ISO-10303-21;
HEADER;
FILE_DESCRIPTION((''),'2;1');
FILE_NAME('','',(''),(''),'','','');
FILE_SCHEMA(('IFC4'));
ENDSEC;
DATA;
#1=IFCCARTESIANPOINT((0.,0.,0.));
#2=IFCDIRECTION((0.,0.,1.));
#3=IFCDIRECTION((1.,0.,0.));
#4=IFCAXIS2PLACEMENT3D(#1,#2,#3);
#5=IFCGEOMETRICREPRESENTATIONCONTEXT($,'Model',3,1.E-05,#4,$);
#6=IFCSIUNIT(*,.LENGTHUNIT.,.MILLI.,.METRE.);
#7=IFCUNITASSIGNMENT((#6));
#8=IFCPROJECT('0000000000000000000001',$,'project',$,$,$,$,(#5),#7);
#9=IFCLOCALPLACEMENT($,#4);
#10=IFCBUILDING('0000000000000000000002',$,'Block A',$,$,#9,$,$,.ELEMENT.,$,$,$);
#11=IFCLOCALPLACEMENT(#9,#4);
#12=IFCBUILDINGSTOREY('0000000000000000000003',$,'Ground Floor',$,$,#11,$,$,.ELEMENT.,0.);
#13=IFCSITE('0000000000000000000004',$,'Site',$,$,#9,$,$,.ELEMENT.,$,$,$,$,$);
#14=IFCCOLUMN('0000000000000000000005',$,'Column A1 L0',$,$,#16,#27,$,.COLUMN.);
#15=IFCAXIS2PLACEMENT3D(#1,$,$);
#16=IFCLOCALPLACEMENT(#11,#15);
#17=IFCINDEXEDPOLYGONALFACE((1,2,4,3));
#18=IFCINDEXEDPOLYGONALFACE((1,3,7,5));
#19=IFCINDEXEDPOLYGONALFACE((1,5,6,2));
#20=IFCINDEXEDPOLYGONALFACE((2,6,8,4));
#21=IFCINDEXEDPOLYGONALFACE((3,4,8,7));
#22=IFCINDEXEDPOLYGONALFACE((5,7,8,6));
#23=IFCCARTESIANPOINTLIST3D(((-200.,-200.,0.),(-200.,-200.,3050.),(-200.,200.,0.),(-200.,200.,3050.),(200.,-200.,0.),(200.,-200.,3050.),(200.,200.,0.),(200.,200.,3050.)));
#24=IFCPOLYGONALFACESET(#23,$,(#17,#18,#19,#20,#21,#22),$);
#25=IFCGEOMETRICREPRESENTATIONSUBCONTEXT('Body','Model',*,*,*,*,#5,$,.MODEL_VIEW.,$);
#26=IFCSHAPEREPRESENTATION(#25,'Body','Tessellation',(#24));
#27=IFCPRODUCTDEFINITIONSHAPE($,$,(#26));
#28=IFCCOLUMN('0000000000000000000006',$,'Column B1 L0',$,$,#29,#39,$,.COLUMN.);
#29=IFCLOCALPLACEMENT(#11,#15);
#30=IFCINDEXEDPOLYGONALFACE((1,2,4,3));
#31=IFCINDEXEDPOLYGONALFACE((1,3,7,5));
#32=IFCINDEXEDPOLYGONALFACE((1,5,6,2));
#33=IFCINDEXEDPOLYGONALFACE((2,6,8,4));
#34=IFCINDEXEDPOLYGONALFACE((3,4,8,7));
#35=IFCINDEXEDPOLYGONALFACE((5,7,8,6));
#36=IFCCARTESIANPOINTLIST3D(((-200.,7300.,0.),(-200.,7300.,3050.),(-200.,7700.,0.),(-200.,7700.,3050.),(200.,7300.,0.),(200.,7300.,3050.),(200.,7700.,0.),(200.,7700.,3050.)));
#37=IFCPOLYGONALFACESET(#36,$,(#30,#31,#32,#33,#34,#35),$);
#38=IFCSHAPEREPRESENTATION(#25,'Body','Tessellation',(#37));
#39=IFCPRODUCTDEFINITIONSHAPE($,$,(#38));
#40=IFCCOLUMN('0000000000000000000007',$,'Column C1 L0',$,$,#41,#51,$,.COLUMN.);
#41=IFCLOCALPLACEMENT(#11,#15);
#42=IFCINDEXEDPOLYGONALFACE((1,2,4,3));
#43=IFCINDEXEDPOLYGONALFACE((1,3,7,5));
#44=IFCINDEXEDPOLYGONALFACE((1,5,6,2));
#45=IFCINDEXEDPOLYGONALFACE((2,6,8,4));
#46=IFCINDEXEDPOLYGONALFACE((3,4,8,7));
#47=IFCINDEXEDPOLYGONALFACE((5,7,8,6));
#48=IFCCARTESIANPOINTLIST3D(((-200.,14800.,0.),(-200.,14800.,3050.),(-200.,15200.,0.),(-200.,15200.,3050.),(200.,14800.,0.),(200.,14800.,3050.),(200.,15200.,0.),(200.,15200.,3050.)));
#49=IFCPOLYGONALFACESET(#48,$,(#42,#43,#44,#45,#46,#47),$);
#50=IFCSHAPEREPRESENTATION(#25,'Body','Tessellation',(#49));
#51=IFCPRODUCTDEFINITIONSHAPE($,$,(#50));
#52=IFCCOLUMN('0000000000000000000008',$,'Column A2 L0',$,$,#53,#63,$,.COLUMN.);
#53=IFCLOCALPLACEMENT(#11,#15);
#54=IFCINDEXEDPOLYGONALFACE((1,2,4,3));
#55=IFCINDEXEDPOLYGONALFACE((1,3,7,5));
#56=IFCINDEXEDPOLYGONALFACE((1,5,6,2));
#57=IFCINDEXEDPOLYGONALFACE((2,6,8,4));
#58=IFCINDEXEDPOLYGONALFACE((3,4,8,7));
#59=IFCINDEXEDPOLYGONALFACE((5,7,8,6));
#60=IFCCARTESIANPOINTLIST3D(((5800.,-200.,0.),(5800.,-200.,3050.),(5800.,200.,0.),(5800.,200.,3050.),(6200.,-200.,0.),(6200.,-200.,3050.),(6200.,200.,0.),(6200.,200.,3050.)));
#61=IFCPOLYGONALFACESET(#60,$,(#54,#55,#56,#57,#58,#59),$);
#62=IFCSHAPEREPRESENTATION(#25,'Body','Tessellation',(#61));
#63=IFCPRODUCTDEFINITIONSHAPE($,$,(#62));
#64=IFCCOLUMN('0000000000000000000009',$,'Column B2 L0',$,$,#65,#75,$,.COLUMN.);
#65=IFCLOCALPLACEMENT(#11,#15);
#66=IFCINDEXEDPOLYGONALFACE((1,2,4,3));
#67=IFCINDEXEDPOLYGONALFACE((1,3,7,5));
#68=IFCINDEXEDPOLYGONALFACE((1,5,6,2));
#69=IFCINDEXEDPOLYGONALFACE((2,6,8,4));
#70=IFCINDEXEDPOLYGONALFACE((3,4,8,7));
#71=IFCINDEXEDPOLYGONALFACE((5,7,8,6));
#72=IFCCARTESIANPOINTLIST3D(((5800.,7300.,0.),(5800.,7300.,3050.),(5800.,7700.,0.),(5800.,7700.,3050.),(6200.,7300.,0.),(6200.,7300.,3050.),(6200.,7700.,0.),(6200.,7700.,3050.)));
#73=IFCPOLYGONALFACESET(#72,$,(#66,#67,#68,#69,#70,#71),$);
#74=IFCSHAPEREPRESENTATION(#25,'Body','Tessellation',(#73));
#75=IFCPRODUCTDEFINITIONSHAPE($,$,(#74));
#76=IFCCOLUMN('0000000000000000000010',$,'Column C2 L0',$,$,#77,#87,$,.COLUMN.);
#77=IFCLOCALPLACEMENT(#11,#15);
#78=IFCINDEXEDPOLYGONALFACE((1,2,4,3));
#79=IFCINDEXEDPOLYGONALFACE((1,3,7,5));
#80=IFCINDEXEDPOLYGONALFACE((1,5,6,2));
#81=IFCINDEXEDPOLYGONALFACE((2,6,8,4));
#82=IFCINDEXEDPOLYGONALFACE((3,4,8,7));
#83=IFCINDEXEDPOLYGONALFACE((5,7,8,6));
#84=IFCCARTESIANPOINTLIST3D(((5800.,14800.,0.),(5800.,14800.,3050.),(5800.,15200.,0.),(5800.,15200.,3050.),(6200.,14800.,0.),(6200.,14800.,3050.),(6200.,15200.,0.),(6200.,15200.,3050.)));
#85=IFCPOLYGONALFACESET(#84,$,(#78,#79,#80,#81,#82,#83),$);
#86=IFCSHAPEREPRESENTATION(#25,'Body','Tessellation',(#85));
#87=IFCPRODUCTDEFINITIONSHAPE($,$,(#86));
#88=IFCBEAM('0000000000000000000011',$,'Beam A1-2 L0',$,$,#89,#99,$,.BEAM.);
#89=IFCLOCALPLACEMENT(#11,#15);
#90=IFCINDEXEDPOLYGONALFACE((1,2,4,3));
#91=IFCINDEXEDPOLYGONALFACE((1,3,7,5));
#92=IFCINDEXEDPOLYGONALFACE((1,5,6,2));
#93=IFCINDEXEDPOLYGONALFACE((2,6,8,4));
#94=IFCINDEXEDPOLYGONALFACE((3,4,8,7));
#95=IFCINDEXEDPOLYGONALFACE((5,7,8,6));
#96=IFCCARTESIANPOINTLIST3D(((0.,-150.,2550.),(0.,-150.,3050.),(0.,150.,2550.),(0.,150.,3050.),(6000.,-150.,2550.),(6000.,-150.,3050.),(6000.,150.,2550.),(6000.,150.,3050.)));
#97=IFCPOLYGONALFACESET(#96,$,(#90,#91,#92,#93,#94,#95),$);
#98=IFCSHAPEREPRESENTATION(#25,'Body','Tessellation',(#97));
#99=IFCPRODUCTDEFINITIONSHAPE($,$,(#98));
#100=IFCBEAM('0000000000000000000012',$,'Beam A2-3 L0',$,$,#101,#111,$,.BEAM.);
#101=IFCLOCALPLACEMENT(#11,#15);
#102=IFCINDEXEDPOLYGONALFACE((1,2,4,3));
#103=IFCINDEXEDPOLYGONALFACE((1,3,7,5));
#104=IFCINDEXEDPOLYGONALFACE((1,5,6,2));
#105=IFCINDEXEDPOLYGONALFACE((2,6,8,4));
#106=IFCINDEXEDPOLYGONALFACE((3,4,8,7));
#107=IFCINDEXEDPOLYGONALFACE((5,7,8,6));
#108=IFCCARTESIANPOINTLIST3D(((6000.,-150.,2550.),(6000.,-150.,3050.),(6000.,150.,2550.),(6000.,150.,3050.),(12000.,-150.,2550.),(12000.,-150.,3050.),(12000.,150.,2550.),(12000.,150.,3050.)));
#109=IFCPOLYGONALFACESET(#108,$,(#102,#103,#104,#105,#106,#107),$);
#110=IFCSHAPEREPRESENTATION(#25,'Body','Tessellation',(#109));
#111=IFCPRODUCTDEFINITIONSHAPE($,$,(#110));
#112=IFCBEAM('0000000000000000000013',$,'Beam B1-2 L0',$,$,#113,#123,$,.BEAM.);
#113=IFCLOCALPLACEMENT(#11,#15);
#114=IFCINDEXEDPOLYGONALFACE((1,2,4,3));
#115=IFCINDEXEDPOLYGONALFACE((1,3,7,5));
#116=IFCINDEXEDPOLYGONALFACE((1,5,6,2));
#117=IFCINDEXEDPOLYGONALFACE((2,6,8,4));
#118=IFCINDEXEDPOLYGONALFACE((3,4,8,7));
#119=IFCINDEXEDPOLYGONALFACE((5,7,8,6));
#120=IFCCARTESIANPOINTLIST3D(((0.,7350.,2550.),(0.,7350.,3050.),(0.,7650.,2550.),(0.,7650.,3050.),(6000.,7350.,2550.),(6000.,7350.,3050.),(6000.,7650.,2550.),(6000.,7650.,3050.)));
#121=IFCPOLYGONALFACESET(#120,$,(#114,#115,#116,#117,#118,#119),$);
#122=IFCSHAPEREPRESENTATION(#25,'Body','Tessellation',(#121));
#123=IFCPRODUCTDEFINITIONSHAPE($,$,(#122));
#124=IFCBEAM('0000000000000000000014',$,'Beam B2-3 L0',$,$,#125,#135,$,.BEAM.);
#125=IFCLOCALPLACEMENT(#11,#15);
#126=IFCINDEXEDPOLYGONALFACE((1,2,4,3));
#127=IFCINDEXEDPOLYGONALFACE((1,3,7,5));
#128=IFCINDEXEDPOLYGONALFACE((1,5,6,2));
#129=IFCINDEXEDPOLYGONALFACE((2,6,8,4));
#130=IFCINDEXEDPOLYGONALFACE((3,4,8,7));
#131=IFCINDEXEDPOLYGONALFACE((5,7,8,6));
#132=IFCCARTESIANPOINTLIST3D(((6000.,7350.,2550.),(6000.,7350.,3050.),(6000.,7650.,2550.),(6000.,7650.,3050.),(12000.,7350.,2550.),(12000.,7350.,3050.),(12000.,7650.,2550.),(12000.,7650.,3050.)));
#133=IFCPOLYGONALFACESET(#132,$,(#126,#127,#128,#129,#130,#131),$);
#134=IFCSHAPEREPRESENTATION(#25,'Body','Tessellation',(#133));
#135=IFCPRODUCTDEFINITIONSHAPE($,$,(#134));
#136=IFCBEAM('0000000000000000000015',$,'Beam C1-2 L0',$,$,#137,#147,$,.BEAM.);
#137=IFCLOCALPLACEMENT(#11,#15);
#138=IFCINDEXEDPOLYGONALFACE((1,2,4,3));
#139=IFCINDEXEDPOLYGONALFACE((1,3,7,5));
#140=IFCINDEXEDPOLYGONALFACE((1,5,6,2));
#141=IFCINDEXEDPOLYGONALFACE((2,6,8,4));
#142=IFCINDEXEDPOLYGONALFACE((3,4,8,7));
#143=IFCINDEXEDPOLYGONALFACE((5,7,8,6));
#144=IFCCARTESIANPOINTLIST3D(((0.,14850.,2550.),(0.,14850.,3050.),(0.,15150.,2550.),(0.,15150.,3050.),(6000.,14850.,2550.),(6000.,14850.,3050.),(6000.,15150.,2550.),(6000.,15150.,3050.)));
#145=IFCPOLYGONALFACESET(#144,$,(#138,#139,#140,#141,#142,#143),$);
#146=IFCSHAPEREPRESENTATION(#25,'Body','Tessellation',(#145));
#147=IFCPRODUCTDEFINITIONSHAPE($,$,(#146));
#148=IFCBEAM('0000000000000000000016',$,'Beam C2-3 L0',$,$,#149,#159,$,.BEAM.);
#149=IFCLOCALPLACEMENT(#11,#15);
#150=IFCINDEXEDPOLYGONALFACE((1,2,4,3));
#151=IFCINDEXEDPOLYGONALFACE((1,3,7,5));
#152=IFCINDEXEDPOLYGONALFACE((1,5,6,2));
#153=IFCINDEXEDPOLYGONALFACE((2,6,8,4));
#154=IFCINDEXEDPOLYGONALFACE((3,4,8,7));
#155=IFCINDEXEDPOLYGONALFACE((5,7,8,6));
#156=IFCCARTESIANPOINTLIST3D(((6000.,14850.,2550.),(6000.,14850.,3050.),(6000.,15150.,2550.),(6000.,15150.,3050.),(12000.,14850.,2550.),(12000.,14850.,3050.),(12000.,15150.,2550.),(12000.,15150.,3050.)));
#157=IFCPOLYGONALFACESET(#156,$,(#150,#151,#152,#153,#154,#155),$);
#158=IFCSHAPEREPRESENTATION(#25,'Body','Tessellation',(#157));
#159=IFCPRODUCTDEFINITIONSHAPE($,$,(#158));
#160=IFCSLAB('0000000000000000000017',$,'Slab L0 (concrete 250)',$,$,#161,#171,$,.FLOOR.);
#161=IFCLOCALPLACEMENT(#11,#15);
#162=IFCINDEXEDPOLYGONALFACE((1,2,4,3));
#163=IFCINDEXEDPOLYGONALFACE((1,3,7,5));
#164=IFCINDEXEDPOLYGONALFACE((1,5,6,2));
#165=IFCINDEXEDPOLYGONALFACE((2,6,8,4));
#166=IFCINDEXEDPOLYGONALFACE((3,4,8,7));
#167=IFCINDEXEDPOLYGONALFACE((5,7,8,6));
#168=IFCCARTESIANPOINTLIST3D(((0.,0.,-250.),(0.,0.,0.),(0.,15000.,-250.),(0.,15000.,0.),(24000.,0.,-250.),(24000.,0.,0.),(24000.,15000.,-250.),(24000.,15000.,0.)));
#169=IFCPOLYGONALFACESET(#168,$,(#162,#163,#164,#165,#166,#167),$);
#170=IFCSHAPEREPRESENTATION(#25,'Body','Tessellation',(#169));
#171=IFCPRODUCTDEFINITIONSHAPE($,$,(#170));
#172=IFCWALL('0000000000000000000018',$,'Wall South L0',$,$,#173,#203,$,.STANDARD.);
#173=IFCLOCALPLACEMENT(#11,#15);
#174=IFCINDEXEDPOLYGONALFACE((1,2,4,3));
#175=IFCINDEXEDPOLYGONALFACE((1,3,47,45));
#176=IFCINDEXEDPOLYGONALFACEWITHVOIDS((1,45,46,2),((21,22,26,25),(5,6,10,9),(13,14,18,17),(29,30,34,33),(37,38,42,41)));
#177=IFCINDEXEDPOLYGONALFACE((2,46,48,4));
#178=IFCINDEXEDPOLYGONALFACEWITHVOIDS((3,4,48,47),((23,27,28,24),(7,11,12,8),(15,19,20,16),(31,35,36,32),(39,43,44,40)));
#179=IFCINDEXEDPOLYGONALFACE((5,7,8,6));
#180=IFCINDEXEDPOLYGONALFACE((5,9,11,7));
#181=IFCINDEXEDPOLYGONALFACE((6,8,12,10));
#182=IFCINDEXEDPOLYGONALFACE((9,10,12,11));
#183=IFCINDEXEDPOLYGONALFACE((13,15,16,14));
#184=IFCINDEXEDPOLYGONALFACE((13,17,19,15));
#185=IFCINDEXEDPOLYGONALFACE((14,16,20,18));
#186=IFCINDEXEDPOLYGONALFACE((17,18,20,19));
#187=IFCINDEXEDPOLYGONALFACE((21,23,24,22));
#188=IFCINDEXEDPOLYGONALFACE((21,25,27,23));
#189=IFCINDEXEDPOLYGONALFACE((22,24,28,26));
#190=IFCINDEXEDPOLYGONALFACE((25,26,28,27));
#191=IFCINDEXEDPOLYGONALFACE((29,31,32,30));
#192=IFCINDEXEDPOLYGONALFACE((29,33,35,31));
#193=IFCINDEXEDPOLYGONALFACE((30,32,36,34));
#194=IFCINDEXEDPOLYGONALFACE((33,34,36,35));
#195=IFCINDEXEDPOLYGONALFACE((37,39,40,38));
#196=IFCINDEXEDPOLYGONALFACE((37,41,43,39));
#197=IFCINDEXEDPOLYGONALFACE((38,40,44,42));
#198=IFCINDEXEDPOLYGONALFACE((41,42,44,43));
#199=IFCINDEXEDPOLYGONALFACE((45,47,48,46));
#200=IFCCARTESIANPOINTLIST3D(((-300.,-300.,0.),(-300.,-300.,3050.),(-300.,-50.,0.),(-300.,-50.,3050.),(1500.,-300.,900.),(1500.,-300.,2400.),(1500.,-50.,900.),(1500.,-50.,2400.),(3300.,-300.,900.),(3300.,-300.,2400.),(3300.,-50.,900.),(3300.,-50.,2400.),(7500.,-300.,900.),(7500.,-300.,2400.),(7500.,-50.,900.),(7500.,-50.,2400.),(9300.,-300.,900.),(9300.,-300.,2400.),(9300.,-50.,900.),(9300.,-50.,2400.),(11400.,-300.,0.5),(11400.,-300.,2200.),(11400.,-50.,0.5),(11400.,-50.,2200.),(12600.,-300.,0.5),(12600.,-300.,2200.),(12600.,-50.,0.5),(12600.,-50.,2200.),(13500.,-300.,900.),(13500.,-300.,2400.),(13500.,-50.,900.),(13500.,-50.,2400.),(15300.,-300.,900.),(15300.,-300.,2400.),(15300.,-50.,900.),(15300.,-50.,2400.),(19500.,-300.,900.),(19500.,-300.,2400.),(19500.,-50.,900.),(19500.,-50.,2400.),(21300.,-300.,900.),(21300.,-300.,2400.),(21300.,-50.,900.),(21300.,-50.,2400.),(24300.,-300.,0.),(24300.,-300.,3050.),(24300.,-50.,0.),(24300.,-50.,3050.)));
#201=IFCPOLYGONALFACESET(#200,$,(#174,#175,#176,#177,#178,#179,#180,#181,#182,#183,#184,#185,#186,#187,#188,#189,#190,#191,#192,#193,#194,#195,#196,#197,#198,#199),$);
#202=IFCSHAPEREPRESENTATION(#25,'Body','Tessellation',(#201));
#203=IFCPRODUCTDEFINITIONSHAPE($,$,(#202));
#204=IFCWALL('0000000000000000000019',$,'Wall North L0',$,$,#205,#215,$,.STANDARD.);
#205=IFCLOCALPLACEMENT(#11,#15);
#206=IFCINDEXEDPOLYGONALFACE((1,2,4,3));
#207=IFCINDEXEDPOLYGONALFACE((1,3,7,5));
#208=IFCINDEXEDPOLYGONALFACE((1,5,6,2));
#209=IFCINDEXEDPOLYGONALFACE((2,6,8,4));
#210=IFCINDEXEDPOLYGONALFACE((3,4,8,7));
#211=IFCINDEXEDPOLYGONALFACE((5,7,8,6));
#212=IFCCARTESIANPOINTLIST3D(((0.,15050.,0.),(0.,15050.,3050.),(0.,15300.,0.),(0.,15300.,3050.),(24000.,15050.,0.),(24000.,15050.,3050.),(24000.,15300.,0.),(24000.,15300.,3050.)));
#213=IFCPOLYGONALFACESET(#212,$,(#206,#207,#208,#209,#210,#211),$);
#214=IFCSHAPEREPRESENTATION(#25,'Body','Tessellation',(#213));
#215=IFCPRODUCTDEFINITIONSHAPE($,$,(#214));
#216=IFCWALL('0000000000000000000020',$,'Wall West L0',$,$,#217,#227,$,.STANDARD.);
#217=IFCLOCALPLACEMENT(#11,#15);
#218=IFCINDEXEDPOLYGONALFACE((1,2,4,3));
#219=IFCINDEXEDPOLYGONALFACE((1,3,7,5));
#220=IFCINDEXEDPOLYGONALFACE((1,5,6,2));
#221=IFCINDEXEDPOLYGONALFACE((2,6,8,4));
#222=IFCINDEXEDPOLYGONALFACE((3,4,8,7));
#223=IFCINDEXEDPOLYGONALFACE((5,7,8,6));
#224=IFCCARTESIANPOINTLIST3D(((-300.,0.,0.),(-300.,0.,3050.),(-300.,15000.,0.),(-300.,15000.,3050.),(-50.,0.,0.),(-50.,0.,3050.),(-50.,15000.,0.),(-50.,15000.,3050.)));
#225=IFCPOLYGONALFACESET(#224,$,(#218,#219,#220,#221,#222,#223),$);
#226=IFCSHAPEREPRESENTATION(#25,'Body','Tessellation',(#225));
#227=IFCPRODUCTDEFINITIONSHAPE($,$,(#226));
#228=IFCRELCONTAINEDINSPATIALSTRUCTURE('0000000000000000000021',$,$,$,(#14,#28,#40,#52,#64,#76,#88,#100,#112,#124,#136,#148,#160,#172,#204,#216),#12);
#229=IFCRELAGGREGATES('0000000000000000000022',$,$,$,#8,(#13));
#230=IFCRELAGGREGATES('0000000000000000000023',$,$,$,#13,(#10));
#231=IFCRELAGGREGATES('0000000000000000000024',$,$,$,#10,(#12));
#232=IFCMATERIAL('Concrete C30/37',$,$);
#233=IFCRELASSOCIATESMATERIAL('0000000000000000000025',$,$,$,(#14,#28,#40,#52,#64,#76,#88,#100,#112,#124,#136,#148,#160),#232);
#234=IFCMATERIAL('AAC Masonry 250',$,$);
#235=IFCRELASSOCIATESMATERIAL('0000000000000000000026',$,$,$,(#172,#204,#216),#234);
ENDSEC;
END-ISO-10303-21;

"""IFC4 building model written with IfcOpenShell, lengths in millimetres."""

from ifc_helpers import new_model, si_unit, frame, frame_2d, origin_with_axes, origin_2d, place, context, subcontext, project, spatial, polyline, rectangle, outline, extrude, material, element, save


model = new_model("IFC4")

# Units and contexts
model_context = context("Model", 3, precision=1e-05, world=origin_with_axes())
body_context = subcontext(model_context, "Body", "Model", "MODEL_VIEW")
ifc_project = project(units=[si_unit("LENGTHUNIT", "METRE", prefix="MILLI")], contexts=[model_context])

# Site, building, storey
placement = place(None, origin_with_axes())
site = spatial("IfcSite", under=ifc_project, at=placement, Name="Site", CompositionType="ELEMENT")
building = spatial("IfcBuilding", under=site, at=placement, Name="Block A", CompositionType="ELEMENT")
storey_placement = place(placement, origin_with_axes())
storey = spatial("IfcBuildingStorey", under=building, at=storey_placement, Name="Ground Floor", CompositionType="ELEMENT", Elevation=0.0)

# Columns
ifc_material_1 = material(Name="Concrete C30/37")
for number, where, z_axis, x_axis, name in (
    (1, (0.0, 0.0, 0.0), (0.0, 0.0, 1.0), (1.0, 0.0, 0.0), "Column A1 L0"),
    (2, (0.0, 7500.0, 0.0), (0.0, 0.0, 1.0), (1.0, 0.0, 0.0), "Column B1 L0"),
    (3, (0.0, 15000.0, 0.0), (0.0, 0.0, 1.0), (1.0, 0.0, 0.0), "Column C1 L0"),
    (4, (6000.0, 0.0, 0.0), (0.0, 0.0, 1.0), (1.0, 0.0, 0.0), "Column A2 L0"),
    (5, (6000.0, 7500.0, 0.0), (0.0, 0.0, 1.0), (1.0, 0.0, 0.0), "Column B2 L0"),
    (6, (6000.0, 15000.0, 0.0), (0.0, 0.0, 1.0), (1.0, 0.0, 0.0), "Column C2 L0"),
):
    element("IfcColumn", number, at=place(placement, frame(where, z_axis=z_axis, x_axis=x_axis)), inside=storey, material=ifc_material_1, Name=name, PredefinedType="COLUMN", context=body_context, shape_type="SweptSolid", body=[
        extrude(rectangle(XDim=400.0, YDim=400.0, at=origin_2d()), origin_with_axes(), (0.0, 0.0, 1.0), 3050.0),
    ])

# Beams
for number, where, z_axis, x_axis, name in (
    (7, (0.0, 0.0, 2550.0), (0.0, 0.0, 1.0), (1.0, 0.0, 0.0), "Beam A1-2 L0"),
    (8, (6000.0, 0.0, 2550.0), (0.0, 0.0, 1.0), (1.0, 0.0, 0.0), "Beam A2-3 L0"),
    (9, (0.0, 7500.0, 2550.0), (0.0, 0.0, 1.0), (1.0, 0.0, 0.0), "Beam B1-2 L0"),
    (10, (6000.0, 7500.0, 2550.0), (0.0, 0.0, 1.0), (1.0, 0.0, 0.0), "Beam B2-3 L0"),
    (11, (0.0, 15000.0, 2550.0), (0.0, 0.0, 1.0), (1.0, 0.0, 0.0), "Beam C1-2 L0"),
    (12, (6000.0, 15000.0, 2550.0), (0.0, 0.0, 1.0), (1.0, 0.0, 0.0), "Beam C2-3 L0"),
):
    element("IfcBeam", number, at=place(placement, frame(where, z_axis=z_axis, x_axis=x_axis)), inside=storey, material=ifc_material_1, Name=name, PredefinedType="BEAM", context=body_context, shape_type="SweptSolid", body=[
        extrude(rectangle(XDim=6000.0, YDim=300.0, at=frame_2d((3000.0, 0.0))), origin_with_axes(), (0.0, 0.0, 1.0), 500.0),
    ])

# Slab
slab_placement = place(placement, frame((0.0, 0.0, -250.0), z_axis=(0.0, 0.0, 1.0), x_axis=(1.0, 0.0, 0.0)))
element("IfcSlab", 13, at=slab_placement, inside=storey, material=ifc_material_1, Name="Slab L0 (concrete 250)", PredefinedType="FLOOR", context=body_context, shape_type="SweptSolid", body=[
    extrude(rectangle(XDim=24000.0, YDim=15000.0, at=frame_2d((12000.0, 7500.0))), origin_with_axes(), (0.0, 0.0, 1.0), 250.0),
])

# Walls
ifc_material_2 = material(Name="AAC Masonry 250")
wall_1_placement = place(placement, origin_with_axes())
element("IfcWall", 14, at=wall_1_placement, inside=storey, material=ifc_material_2, Name="Wall South L0", PredefinedType="STANDARD", context=body_context, shape_type="SweptSolid", body=[
    extrude(outline(polyline([(-300.0, 0.0), (24300.0, 0.0), (24300.0, 3050.0), (-300.0, 3050.0), (-300.0, 0.0)]), holes=[polyline([(1500.0, 900.0), (3300.0, 900.0), (3300.0, 2400.0), (1500.0, 2400.0), (1500.0, 900.0)]), polyline([(7500.0, 900.0), (9300.0, 900.0), (9300.0, 2400.0), (7500.0, 2400.0), (7500.0, 900.0)]), polyline([(13500.0, 900.0), (15300.0, 900.0), (15300.0, 2400.0), (13500.0, 2400.0), (13500.0, 900.0)]), polyline([(19500.0, 900.0), (21300.0, 900.0), (21300.0, 2400.0), (19500.0, 2400.0), (19500.0, 900.0)]), polyline([(11400.0, 0.5), (12600.0, 0.5), (12600.0, 2200.0), (11400.0, 2200.0), (11400.0, 0.5)])]), frame((0.0, -50.0, 0.0), z_axis=(0.0, -1.0, 0.0), x_axis=(1.0, 0.0, 0.0)), (0.0, 0.0, 1.0), 250.0),
])
wall_2_placement = place(placement, frame((0.0, 15050.0, 0.0), z_axis=(0.0, 0.0, 1.0), x_axis=(1.0, 0.0, 0.0)))
element("IfcWall", 15, at=wall_2_placement, inside=storey, material=ifc_material_2, Name="Wall North L0", PredefinedType="STANDARD", context=body_context, shape_type="SweptSolid", body=[
    extrude(rectangle(XDim=24000.0, YDim=250.0, at=frame_2d((12000.0, 125.0))), origin_with_axes(), (0.0, 0.0, 1.0), 3050.0),
])
wall_3_placement = place(placement, frame((-300.0, 0.0, 0.0), z_axis=(0.0, 0.0, 1.0), x_axis=(1.0, 0.0, 0.0)))
element("IfcWall", 16, at=wall_3_placement, inside=storey, material=ifc_material_2, Name="Wall West L0", PredefinedType="STANDARD", context=body_context, shape_type="SweptSolid", body=[
    extrude(rectangle(XDim=250.0, YDim=15000.0, at=frame_2d((125.0, 7500.0))), origin_with_axes(), (0.0, 0.0, 1.0), 3050.0),
])

save(model, "model.ifc")
